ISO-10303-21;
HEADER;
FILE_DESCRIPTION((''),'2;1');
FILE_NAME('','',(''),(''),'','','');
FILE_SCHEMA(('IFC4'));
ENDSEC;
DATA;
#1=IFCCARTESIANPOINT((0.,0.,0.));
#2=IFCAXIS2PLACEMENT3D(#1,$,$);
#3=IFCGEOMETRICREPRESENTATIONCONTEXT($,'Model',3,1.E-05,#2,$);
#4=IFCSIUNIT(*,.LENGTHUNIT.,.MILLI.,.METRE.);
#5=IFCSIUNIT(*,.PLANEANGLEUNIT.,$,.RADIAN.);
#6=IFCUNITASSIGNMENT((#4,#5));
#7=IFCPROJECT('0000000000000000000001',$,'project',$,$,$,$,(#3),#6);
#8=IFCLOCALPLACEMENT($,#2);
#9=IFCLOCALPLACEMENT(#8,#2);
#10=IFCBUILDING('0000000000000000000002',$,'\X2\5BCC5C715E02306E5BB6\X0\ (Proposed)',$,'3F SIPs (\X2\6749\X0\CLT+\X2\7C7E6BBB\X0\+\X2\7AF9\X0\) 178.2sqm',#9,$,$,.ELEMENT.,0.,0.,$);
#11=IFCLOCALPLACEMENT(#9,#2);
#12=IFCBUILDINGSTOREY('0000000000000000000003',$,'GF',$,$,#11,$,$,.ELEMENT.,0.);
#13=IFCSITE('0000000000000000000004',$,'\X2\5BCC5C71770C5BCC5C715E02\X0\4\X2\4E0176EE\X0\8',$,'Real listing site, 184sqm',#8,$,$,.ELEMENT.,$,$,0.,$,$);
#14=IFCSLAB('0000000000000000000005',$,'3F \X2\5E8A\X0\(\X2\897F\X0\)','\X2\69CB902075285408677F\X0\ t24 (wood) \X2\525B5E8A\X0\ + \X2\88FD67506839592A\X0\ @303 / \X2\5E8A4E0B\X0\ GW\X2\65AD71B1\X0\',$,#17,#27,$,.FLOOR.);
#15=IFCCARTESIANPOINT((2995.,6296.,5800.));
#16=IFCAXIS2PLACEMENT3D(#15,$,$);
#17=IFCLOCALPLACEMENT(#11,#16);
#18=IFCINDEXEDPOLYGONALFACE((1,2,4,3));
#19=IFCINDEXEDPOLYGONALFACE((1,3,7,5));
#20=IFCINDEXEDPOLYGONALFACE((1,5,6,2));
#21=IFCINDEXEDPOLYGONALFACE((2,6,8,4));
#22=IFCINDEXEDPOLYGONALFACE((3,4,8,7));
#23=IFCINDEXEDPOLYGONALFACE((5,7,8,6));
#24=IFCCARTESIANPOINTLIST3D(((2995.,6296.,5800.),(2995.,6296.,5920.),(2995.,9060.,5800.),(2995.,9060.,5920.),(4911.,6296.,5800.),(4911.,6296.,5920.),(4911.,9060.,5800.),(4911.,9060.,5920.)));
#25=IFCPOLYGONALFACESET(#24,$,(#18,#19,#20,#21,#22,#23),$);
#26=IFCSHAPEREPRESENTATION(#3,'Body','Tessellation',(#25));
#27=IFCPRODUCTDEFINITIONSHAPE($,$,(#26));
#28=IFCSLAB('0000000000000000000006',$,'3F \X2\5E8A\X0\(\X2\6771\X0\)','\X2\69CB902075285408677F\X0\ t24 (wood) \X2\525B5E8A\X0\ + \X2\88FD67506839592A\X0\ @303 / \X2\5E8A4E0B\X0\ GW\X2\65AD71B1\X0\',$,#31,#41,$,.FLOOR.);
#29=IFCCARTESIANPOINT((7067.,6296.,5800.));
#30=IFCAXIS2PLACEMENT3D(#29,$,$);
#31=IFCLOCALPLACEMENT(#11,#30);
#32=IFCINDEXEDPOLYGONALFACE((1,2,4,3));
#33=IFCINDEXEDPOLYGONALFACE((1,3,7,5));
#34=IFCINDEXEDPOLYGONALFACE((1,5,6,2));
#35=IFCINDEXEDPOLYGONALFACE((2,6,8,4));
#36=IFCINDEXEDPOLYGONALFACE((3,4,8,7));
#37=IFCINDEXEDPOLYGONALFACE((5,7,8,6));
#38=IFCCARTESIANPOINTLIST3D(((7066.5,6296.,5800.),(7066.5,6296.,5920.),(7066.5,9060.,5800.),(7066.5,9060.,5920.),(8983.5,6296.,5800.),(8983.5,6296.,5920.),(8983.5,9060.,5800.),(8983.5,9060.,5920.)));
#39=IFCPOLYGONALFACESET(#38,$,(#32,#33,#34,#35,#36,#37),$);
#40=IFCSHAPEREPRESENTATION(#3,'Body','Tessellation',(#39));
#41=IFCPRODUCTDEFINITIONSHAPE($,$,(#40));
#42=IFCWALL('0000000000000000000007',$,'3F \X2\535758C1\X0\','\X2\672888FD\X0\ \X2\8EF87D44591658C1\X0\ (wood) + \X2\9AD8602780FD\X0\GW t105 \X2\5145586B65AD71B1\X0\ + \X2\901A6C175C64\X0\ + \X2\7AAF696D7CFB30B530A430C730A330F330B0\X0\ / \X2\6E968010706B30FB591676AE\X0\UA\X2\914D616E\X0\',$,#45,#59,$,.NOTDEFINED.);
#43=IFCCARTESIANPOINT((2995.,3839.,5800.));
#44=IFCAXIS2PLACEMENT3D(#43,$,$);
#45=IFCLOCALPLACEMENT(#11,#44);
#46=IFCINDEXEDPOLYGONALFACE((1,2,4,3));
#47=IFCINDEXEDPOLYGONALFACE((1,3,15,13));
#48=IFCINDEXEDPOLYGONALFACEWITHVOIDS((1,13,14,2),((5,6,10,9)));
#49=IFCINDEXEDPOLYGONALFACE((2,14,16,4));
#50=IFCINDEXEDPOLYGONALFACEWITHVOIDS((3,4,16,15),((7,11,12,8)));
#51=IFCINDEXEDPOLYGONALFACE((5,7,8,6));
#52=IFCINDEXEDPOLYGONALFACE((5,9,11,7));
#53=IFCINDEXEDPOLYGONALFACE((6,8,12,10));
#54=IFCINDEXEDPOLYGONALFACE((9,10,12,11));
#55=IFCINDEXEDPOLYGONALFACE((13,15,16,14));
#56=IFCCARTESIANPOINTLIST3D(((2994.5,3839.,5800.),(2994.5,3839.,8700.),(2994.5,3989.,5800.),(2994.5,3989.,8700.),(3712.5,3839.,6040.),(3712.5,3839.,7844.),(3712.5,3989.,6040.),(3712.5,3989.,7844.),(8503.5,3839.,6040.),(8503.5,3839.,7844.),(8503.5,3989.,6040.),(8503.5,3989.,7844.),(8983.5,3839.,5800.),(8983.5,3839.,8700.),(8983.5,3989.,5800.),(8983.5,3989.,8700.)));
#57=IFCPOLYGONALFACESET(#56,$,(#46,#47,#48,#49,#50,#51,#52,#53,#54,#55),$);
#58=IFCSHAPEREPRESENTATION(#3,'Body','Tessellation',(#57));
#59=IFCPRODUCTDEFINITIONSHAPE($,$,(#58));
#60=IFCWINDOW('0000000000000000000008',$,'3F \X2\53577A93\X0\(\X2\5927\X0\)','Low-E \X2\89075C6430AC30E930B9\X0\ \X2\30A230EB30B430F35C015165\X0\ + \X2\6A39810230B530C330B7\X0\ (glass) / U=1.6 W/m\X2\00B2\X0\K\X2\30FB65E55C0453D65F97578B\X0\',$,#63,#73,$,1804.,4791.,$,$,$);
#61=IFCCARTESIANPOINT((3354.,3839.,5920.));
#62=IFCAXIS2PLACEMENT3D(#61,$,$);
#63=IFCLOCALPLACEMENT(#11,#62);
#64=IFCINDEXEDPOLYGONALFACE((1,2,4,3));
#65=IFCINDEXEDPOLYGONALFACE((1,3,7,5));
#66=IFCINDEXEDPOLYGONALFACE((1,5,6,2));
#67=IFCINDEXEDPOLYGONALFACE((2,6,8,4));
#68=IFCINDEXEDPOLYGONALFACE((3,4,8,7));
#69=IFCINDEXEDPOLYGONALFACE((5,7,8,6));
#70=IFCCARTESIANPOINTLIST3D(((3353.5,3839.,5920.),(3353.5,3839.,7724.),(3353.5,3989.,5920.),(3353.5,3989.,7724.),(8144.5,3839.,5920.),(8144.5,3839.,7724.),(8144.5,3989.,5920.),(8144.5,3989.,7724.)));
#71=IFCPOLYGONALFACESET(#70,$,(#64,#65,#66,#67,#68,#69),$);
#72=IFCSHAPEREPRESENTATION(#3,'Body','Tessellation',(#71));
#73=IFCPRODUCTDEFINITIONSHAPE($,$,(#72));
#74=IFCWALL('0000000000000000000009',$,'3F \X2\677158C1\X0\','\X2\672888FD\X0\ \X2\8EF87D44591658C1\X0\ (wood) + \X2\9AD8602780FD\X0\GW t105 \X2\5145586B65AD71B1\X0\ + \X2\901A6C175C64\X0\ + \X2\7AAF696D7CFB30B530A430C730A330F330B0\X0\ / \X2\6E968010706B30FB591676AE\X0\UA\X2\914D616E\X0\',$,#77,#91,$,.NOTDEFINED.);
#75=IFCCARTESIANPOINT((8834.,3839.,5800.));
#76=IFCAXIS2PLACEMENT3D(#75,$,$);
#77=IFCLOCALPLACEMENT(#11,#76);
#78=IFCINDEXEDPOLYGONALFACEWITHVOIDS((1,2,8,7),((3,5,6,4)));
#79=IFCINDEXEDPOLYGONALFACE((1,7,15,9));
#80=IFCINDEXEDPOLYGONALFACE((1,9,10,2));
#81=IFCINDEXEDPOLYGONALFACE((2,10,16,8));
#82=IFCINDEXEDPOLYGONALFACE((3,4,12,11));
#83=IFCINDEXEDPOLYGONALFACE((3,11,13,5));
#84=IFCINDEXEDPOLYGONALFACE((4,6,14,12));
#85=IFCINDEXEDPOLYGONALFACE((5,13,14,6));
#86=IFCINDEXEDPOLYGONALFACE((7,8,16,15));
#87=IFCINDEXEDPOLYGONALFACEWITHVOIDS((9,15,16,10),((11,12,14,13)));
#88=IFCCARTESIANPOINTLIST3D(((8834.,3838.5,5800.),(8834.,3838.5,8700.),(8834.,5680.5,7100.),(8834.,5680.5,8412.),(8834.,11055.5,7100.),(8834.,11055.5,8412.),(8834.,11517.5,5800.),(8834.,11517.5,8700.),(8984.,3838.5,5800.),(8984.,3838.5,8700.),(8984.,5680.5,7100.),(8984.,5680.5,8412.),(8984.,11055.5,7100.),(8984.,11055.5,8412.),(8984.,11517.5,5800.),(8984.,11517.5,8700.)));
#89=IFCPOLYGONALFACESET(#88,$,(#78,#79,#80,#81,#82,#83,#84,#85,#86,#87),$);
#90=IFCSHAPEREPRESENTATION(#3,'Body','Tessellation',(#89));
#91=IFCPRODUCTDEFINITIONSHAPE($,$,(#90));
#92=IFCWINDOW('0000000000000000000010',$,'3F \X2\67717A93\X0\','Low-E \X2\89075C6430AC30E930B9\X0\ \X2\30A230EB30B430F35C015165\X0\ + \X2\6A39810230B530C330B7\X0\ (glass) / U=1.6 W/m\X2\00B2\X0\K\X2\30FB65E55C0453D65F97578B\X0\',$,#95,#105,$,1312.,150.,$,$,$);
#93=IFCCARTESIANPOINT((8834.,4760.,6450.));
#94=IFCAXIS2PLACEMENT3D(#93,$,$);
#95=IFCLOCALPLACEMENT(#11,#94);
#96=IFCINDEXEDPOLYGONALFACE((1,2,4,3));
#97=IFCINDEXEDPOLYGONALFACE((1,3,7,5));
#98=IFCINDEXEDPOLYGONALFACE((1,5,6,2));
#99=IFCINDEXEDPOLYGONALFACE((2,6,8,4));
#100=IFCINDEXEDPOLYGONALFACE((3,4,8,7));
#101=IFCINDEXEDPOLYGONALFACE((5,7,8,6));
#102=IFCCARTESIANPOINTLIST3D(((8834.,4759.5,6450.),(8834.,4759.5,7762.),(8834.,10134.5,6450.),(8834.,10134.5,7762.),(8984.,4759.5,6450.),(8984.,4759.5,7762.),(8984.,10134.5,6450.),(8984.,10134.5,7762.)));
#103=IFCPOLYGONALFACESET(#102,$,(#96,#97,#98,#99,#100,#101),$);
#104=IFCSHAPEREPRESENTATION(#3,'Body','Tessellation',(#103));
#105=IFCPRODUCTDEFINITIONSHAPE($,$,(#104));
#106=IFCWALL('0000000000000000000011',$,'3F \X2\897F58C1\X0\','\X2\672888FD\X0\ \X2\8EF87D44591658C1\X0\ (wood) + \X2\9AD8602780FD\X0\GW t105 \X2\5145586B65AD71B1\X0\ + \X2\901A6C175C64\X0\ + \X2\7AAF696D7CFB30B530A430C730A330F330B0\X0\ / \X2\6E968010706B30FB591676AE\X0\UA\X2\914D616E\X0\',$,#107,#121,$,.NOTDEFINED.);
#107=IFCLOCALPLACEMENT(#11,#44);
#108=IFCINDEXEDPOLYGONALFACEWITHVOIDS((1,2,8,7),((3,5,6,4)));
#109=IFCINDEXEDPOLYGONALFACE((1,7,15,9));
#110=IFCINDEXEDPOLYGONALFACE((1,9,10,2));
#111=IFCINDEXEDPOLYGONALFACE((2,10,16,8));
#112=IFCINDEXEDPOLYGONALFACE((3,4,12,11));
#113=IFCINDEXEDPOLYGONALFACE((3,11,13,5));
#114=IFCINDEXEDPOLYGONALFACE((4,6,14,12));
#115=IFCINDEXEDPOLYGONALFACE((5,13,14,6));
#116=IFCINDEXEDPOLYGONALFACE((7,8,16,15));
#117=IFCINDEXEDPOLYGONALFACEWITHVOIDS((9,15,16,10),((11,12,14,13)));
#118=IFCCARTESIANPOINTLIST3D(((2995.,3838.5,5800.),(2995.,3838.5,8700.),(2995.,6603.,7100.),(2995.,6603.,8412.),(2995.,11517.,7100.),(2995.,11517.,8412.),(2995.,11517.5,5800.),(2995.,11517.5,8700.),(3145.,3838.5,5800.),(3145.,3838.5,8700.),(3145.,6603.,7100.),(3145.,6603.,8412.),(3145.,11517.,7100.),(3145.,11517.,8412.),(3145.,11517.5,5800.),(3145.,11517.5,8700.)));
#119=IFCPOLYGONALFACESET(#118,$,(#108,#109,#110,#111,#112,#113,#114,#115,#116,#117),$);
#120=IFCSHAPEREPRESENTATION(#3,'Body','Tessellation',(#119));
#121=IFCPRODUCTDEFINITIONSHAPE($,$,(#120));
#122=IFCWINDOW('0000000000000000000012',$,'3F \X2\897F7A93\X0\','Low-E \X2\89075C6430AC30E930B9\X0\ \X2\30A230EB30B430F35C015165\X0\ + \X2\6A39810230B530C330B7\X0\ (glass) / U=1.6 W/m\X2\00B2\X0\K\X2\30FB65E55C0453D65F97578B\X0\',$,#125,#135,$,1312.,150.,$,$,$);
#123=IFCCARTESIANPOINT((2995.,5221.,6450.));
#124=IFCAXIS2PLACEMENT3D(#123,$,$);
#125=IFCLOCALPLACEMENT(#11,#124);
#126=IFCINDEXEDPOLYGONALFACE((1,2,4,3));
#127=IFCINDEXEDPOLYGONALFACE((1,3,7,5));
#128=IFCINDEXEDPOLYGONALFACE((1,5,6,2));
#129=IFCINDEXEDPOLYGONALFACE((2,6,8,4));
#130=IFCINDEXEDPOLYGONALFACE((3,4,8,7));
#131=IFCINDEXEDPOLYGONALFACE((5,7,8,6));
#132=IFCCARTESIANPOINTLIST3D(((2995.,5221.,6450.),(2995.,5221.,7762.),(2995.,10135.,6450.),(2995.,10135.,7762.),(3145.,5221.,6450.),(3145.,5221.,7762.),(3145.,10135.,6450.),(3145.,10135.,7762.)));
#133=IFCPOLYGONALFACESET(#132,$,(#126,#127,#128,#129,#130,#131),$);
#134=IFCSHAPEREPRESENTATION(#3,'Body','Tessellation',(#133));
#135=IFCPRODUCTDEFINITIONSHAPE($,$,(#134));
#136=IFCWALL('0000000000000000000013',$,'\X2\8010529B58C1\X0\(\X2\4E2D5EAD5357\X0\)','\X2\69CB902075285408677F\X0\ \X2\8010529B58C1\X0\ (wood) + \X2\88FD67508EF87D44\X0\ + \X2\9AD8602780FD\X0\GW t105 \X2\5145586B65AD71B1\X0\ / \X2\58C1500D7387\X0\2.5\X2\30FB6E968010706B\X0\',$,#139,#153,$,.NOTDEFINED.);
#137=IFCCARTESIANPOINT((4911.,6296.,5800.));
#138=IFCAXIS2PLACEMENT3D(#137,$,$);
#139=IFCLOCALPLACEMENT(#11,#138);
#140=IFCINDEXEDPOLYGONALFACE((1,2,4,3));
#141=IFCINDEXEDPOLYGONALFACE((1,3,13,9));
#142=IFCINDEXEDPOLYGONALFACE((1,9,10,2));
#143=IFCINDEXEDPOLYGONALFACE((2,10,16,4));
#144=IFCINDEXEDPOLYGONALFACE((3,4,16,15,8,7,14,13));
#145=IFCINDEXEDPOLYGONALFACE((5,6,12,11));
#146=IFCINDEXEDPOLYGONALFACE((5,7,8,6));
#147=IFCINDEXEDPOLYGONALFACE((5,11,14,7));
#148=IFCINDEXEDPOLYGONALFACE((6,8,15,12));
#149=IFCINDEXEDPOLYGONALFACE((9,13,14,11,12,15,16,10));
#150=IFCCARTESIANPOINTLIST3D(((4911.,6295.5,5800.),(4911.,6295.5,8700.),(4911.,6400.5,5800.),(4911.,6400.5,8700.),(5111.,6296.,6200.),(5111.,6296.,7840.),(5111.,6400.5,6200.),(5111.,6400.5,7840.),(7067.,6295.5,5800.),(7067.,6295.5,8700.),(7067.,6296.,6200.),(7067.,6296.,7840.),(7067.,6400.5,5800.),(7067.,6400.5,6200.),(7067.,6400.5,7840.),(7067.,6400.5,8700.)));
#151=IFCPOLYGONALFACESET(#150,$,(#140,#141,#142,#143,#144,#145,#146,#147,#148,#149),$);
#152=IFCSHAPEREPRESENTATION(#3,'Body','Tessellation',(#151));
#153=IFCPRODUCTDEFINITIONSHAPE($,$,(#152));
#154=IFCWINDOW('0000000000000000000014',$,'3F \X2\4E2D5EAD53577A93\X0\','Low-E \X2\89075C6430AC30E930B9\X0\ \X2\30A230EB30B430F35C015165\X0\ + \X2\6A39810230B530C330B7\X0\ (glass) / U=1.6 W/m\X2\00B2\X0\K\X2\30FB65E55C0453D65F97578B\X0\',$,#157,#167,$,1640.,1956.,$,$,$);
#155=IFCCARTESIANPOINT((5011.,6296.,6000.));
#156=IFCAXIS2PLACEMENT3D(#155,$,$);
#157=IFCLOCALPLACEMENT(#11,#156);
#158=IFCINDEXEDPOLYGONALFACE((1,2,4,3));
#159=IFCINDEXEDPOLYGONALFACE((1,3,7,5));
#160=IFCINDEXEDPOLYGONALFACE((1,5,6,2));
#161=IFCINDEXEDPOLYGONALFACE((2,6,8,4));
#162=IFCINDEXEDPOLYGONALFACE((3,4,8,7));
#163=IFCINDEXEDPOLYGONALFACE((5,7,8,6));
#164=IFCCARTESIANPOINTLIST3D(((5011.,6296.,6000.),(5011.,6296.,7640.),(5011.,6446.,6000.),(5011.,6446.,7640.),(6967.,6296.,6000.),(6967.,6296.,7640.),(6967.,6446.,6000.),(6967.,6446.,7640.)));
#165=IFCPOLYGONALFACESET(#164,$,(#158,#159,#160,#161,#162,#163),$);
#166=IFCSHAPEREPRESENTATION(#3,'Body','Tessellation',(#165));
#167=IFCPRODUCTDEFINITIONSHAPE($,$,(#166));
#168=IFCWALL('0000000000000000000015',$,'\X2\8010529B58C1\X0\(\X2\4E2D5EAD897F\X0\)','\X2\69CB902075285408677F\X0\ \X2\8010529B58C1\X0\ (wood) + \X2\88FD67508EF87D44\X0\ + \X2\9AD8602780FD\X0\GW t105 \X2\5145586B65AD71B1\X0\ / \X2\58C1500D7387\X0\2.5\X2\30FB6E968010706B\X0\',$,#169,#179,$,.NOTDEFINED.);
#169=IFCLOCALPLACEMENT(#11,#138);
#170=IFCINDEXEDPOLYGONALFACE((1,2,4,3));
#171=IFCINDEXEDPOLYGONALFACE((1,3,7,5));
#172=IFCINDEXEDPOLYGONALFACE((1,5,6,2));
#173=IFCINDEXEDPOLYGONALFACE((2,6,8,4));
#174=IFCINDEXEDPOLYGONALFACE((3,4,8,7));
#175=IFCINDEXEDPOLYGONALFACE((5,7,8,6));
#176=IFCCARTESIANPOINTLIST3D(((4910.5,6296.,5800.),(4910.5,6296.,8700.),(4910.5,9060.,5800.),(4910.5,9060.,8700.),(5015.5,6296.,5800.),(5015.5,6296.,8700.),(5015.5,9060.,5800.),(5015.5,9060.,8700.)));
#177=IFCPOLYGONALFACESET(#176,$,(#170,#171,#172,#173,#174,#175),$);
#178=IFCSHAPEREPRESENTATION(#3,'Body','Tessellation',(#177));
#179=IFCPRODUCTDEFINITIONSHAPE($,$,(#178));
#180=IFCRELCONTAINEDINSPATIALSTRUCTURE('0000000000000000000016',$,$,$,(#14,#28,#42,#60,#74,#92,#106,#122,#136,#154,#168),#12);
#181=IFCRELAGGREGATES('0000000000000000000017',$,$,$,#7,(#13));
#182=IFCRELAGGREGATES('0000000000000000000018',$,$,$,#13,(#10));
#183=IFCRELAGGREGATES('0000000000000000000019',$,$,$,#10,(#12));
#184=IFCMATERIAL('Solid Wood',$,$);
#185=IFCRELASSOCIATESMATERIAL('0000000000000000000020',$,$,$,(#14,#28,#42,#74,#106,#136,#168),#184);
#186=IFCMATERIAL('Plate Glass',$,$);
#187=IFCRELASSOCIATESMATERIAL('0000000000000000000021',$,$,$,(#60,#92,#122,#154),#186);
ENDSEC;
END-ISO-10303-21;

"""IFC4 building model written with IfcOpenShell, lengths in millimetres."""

from ifc_helpers import new_model, si_unit, frame, frame_2d, origin, place, context, project, spatial, rectangle, extrude, material, element, fill, save


model = new_model("IFC4")

# Units and contexts
model_context = context("Model", 3, precision=1e-05, world=origin())
ifc_project = project(units=[si_unit("LENGTHUNIT", "METRE", prefix="MILLI"), si_unit("PLANEANGLEUNIT", "RADIAN")], contexts=[model_context])

# Site, building, storey
site_placement = place(None, origin())
site = spatial("IfcSite", under=ifc_project, at=site_placement, Name="富山県富山市4丁目8", ObjectType="Real listing site, 184sqm", CompositionType="ELEMENT", RefElevation=0.0)
building_placement = place(site_placement, origin())
building = spatial("IfcBuilding", under=site, at=building_placement, Name="富山市の家 (Proposed)", ObjectType="3F SIPs (杉CLT+籾殻+竹) 178.2sqm", CompositionType="ELEMENT", ElevationOfRefHeight=0.0, ElevationOfTerrain=0.0)
storey_placement = place(building_placement, origin())
storey = spatial("IfcBuildingStorey", under=building, at=storey_placement, Name="GF", CompositionType="ELEMENT", Elevation=0.0)

# Slabs
ifc_material_1 = material(Name="Solid Wood")
slab_1_placement = place(storey_placement, frame((2995.0, 6296.0, 5800.0)))
element("IfcSlab", 1, at=slab_1_placement, inside=storey, material=ifc_material_1, Name="3F 床(西)", Description="構造用合板 t24 (wood) 剛床 + 製材根太 @303 / 床下 GW断熱", PredefinedType="FLOOR", context=model_context, shape_type="SweptSolid", body=[
    extrude(rectangle(XDim=1916.0, YDim=2764.0, at=frame_2d((958.0, 1382.0))), frame((2995.0, 6296.0, 5800.0)), (0.0, 0.0, 1.0), 120.0),
])
slab_2_placement = place(storey_placement, frame((7067.0, 6296.0, 5800.0)))
element("IfcSlab", 2, at=slab_2_placement, inside=storey, material=ifc_material_1, Name="3F 床(東)", Description="構造用合板 t24 (wood) 剛床 + 製材根太 @303 / 床下 GW断熱", PredefinedType="FLOOR", context=model_context, shape_type="SweptSolid", body=[
    extrude(rectangle(XDim=1917.0, YDim=2764.0, at=frame_2d((958.0, 1382.0))), frame((7067.0, 6296.0, 5800.0)), (0.0, 0.0, 1.0), 120.0),
])

# Walls, openings, windows
wall_1_placement = place(storey_placement, frame((2995.0, 3839.0, 5800.0)))
wall_1 = element("IfcWall", 3, at=wall_1_placement, inside=storey, material=ifc_material_1, Name="3F 南壁", Description="木製 軸組外壁 (wood) + 高性能GW t105 充填断熱 + 通気層 + 窯業系サイディング / 準耐火・外皮UA配慮", PredefinedType="NOTDEFINED", context=model_context, shape_type="SweptSolid", body=[
    extrude(rectangle(XDim=5989.0, YDim=150.0, at=frame_2d((2994.0, 75.0))), frame((2995.0, 3839.0, 5800.0)), (0.0, 0.0, 1.0), 2900.0),
])
opening_1_placement = place(storey_placement, frame((3354.0, 3839.0, 5920.0)))
opening_1 = element("IfcOpeningElement", 4, at=opening_1_placement, cuts=wall_1, PredefinedType="NOTDEFINED", context=model_context, shape_type="SweptSolid", body=[
    extrude(rectangle(XDim=4791.0, YDim=150.0, at=frame_2d((2395.0, 75.0))), frame((3354.0, 3839.0, 5920.0)), (0.0, 0.0, 1.0), 1804.0),
])
ifc_material_2 = material(Name="Plate Glass")
window_1_placement = place(storey_placement, frame((3354.0, 3839.0, 5920.0)))
window_1 = element("IfcWindow", 5, at=window_1_placement, inside=storey, material=ifc_material_2, Name="3F 南窓(大)", Description="Low-E 複層ガラス アルゴン封入 + 樹脂サッシ (glass) / U=1.6 W/m²K・日射取得型", OverallHeight=1804.0, OverallWidth=4791.0, context=model_context, shape_type="SweptSolid", body=[
    extrude(rectangle(XDim=4791.0, YDim=150.0, at=frame_2d((2395.0, 75.0))), frame((3354.0, 3839.0, 5920.0)), (0.0, 0.0, 1.0), 1804.0),
])
fill(opening_1, window_1)
wall_2_placement = place(storey_placement, frame((8834.0, 3839.0, 5800.0)))
wall_2 = element("IfcWall", 6, at=wall_2_placement, inside=storey, material=ifc_material_1, Name="3F 東壁", Description="木製 軸組外壁 (wood) + 高性能GW t105 充填断熱 + 通気層 + 窯業系サイディング / 準耐火・外皮UA配慮", PredefinedType="NOTDEFINED", context=model_context, shape_type="SweptSolid", body=[
    extrude(rectangle(XDim=150.0, YDim=7679.0, at=frame_2d((75.0, 3839.0))), frame((8834.0, 3839.0, 5800.0)), (0.0, 0.0, 1.0), 2900.0),
])
opening_2_placement = place(storey_placement, frame((8834.0, 4760.0, 6450.0)))
opening_2 = element("IfcOpeningElement", 7, at=opening_2_placement, cuts=wall_2, PredefinedType="NOTDEFINED", context=model_context, shape_type="SweptSolid", body=[
    extrude(rectangle(XDim=150.0, YDim=5375.0, at=frame_2d((75.0, 2687.0))), frame((8834.0, 4760.0, 6450.0)), (0.0, 0.0, 1.0), 1312.0),
])
window_2_placement = place(storey_placement, frame((8834.0, 4760.0, 6450.0)))
window_2 = element("IfcWindow", 8, at=window_2_placement, inside=storey, material=ifc_material_2, Name="3F 東窓", Description="Low-E 複層ガラス アルゴン封入 + 樹脂サッシ (glass) / U=1.6 W/m²K・日射取得型", OverallHeight=1312.0, OverallWidth=150.0, context=model_context, shape_type="SweptSolid", body=[
    extrude(rectangle(XDim=150.0, YDim=5375.0, at=frame_2d((75.0, 2687.0))), frame((8834.0, 4760.0, 6450.0)), (0.0, 0.0, 1.0), 1312.0),
])
fill(opening_2, window_2)
wall_3_placement = place(storey_placement, frame((2995.0, 3839.0, 5800.0)))
wall_3 = element("IfcWall", 9, at=wall_3_placement, inside=storey, material=ifc_material_1, Name="3F 西壁", Description="木製 軸組外壁 (wood) + 高性能GW t105 充填断熱 + 通気層 + 窯業系サイディング / 準耐火・外皮UA配慮", PredefinedType="NOTDEFINED", context=model_context, shape_type="SweptSolid", body=[
    extrude(rectangle(XDim=150.0, YDim=7679.0, at=frame_2d((75.0, 3839.0))), frame((2995.0, 3839.0, 5800.0)), (0.0, 0.0, 1.0), 2900.0),
])
opening_3_placement = place(storey_placement, frame((2995.0, 5221.0, 6450.0)))
opening_3 = element("IfcOpeningElement", 10, at=opening_3_placement, cuts=wall_3, PredefinedType="NOTDEFINED", context=model_context, shape_type="SweptSolid", body=[
    extrude(rectangle(XDim=150.0, YDim=4914.0, at=frame_2d((75.0, 2457.0))), frame((2995.0, 5221.0, 6450.0)), (0.0, 0.0, 1.0), 1312.0),
])
window_3_placement = place(storey_placement, frame((2995.0, 5221.0, 6450.0)))
window_3 = element("IfcWindow", 11, at=window_3_placement, inside=storey, material=ifc_material_2, Name="3F 西窓", Description="Low-E 複層ガラス アルゴン封入 + 樹脂サッシ (glass) / U=1.6 W/m²K・日射取得型", OverallHeight=1312.0, OverallWidth=150.0, context=model_context, shape_type="SweptSolid", body=[
    extrude(rectangle(XDim=150.0, YDim=4914.0, at=frame_2d((75.0, 2457.0))), frame((2995.0, 5221.0, 6450.0)), (0.0, 0.0, 1.0), 1312.0),
])
fill(opening_3, window_3)
wall_4_placement = place(storey_placement, frame((4911.0, 6296.0, 5800.0)))
wall_4 = element("IfcWall", 12, at=wall_4_placement, inside=storey, material=ifc_material_1, Name="耐力壁(中庭南)", Description="構造用合板 耐力壁 (wood) + 製材軸組 + 高性能GW t105 充填断熱 / 壁倍率2.5・準耐火", PredefinedType="NOTDEFINED", context=model_context, shape_type="SweptSolid", body=[
    extrude(rectangle(XDim=2156.0, YDim=105.0, at=frame_2d((1078.0, 52.0))), frame((4911.0, 6296.0, 5800.0)), (0.0, 0.0, 1.0), 2900.0),
])
opening_4_placement = place(storey_placement, frame((5011.0, 6296.0, 6000.0)))
opening_4 = element("IfcOpeningElement", 13, at=opening_4_placement, cuts=wall_4, PredefinedType="NOTDEFINED", context=model_context, shape_type="SweptSolid", body=[
    extrude(rectangle(XDim=1956.0, YDim=150.0, at=frame_2d((978.0, 75.0))), frame((5011.0, 6296.0, 6000.0)), (0.0, 0.0, 1.0), 1640.0),
])
window_4_placement = place(storey_placement, frame((5011.0, 6296.0, 6000.0)))
window_4 = element("IfcWindow", 14, at=window_4_placement, inside=storey, material=ifc_material_2, Name="3F 中庭南窓", Description="Low-E 複層ガラス アルゴン封入 + 樹脂サッシ (glass) / U=1.6 W/m²K・日射取得型", OverallHeight=1640.0, OverallWidth=1956.0, context=model_context, shape_type="SweptSolid", body=[
    extrude(rectangle(XDim=1956.0, YDim=150.0, at=frame_2d((978.0, 75.0))), frame((5011.0, 6296.0, 6000.0)), (0.0, 0.0, 1.0), 1640.0),
])
fill(opening_4, window_4)

# Wall
wall_5_placement = place(storey_placement, frame((4911.0, 6296.0, 5800.0)))
element("IfcWall", 15, at=wall_5_placement, inside=storey, material=ifc_material_1, Name="耐力壁(中庭西)", Description="構造用合板 耐力壁 (wood) + 製材軸組 + 高性能GW t105 充填断熱 / 壁倍率2.5・準耐火", PredefinedType="NOTDEFINED", context=model_context, shape_type="SweptSolid", body=[
    extrude(rectangle(XDim=105.0, YDim=2764.0, at=frame_2d((52.0, 1382.0))), frame((4911.0, 6296.0, 5800.0)), (0.0, 0.0, 1.0), 2900.0),
])

save(model, "model.ifc")
